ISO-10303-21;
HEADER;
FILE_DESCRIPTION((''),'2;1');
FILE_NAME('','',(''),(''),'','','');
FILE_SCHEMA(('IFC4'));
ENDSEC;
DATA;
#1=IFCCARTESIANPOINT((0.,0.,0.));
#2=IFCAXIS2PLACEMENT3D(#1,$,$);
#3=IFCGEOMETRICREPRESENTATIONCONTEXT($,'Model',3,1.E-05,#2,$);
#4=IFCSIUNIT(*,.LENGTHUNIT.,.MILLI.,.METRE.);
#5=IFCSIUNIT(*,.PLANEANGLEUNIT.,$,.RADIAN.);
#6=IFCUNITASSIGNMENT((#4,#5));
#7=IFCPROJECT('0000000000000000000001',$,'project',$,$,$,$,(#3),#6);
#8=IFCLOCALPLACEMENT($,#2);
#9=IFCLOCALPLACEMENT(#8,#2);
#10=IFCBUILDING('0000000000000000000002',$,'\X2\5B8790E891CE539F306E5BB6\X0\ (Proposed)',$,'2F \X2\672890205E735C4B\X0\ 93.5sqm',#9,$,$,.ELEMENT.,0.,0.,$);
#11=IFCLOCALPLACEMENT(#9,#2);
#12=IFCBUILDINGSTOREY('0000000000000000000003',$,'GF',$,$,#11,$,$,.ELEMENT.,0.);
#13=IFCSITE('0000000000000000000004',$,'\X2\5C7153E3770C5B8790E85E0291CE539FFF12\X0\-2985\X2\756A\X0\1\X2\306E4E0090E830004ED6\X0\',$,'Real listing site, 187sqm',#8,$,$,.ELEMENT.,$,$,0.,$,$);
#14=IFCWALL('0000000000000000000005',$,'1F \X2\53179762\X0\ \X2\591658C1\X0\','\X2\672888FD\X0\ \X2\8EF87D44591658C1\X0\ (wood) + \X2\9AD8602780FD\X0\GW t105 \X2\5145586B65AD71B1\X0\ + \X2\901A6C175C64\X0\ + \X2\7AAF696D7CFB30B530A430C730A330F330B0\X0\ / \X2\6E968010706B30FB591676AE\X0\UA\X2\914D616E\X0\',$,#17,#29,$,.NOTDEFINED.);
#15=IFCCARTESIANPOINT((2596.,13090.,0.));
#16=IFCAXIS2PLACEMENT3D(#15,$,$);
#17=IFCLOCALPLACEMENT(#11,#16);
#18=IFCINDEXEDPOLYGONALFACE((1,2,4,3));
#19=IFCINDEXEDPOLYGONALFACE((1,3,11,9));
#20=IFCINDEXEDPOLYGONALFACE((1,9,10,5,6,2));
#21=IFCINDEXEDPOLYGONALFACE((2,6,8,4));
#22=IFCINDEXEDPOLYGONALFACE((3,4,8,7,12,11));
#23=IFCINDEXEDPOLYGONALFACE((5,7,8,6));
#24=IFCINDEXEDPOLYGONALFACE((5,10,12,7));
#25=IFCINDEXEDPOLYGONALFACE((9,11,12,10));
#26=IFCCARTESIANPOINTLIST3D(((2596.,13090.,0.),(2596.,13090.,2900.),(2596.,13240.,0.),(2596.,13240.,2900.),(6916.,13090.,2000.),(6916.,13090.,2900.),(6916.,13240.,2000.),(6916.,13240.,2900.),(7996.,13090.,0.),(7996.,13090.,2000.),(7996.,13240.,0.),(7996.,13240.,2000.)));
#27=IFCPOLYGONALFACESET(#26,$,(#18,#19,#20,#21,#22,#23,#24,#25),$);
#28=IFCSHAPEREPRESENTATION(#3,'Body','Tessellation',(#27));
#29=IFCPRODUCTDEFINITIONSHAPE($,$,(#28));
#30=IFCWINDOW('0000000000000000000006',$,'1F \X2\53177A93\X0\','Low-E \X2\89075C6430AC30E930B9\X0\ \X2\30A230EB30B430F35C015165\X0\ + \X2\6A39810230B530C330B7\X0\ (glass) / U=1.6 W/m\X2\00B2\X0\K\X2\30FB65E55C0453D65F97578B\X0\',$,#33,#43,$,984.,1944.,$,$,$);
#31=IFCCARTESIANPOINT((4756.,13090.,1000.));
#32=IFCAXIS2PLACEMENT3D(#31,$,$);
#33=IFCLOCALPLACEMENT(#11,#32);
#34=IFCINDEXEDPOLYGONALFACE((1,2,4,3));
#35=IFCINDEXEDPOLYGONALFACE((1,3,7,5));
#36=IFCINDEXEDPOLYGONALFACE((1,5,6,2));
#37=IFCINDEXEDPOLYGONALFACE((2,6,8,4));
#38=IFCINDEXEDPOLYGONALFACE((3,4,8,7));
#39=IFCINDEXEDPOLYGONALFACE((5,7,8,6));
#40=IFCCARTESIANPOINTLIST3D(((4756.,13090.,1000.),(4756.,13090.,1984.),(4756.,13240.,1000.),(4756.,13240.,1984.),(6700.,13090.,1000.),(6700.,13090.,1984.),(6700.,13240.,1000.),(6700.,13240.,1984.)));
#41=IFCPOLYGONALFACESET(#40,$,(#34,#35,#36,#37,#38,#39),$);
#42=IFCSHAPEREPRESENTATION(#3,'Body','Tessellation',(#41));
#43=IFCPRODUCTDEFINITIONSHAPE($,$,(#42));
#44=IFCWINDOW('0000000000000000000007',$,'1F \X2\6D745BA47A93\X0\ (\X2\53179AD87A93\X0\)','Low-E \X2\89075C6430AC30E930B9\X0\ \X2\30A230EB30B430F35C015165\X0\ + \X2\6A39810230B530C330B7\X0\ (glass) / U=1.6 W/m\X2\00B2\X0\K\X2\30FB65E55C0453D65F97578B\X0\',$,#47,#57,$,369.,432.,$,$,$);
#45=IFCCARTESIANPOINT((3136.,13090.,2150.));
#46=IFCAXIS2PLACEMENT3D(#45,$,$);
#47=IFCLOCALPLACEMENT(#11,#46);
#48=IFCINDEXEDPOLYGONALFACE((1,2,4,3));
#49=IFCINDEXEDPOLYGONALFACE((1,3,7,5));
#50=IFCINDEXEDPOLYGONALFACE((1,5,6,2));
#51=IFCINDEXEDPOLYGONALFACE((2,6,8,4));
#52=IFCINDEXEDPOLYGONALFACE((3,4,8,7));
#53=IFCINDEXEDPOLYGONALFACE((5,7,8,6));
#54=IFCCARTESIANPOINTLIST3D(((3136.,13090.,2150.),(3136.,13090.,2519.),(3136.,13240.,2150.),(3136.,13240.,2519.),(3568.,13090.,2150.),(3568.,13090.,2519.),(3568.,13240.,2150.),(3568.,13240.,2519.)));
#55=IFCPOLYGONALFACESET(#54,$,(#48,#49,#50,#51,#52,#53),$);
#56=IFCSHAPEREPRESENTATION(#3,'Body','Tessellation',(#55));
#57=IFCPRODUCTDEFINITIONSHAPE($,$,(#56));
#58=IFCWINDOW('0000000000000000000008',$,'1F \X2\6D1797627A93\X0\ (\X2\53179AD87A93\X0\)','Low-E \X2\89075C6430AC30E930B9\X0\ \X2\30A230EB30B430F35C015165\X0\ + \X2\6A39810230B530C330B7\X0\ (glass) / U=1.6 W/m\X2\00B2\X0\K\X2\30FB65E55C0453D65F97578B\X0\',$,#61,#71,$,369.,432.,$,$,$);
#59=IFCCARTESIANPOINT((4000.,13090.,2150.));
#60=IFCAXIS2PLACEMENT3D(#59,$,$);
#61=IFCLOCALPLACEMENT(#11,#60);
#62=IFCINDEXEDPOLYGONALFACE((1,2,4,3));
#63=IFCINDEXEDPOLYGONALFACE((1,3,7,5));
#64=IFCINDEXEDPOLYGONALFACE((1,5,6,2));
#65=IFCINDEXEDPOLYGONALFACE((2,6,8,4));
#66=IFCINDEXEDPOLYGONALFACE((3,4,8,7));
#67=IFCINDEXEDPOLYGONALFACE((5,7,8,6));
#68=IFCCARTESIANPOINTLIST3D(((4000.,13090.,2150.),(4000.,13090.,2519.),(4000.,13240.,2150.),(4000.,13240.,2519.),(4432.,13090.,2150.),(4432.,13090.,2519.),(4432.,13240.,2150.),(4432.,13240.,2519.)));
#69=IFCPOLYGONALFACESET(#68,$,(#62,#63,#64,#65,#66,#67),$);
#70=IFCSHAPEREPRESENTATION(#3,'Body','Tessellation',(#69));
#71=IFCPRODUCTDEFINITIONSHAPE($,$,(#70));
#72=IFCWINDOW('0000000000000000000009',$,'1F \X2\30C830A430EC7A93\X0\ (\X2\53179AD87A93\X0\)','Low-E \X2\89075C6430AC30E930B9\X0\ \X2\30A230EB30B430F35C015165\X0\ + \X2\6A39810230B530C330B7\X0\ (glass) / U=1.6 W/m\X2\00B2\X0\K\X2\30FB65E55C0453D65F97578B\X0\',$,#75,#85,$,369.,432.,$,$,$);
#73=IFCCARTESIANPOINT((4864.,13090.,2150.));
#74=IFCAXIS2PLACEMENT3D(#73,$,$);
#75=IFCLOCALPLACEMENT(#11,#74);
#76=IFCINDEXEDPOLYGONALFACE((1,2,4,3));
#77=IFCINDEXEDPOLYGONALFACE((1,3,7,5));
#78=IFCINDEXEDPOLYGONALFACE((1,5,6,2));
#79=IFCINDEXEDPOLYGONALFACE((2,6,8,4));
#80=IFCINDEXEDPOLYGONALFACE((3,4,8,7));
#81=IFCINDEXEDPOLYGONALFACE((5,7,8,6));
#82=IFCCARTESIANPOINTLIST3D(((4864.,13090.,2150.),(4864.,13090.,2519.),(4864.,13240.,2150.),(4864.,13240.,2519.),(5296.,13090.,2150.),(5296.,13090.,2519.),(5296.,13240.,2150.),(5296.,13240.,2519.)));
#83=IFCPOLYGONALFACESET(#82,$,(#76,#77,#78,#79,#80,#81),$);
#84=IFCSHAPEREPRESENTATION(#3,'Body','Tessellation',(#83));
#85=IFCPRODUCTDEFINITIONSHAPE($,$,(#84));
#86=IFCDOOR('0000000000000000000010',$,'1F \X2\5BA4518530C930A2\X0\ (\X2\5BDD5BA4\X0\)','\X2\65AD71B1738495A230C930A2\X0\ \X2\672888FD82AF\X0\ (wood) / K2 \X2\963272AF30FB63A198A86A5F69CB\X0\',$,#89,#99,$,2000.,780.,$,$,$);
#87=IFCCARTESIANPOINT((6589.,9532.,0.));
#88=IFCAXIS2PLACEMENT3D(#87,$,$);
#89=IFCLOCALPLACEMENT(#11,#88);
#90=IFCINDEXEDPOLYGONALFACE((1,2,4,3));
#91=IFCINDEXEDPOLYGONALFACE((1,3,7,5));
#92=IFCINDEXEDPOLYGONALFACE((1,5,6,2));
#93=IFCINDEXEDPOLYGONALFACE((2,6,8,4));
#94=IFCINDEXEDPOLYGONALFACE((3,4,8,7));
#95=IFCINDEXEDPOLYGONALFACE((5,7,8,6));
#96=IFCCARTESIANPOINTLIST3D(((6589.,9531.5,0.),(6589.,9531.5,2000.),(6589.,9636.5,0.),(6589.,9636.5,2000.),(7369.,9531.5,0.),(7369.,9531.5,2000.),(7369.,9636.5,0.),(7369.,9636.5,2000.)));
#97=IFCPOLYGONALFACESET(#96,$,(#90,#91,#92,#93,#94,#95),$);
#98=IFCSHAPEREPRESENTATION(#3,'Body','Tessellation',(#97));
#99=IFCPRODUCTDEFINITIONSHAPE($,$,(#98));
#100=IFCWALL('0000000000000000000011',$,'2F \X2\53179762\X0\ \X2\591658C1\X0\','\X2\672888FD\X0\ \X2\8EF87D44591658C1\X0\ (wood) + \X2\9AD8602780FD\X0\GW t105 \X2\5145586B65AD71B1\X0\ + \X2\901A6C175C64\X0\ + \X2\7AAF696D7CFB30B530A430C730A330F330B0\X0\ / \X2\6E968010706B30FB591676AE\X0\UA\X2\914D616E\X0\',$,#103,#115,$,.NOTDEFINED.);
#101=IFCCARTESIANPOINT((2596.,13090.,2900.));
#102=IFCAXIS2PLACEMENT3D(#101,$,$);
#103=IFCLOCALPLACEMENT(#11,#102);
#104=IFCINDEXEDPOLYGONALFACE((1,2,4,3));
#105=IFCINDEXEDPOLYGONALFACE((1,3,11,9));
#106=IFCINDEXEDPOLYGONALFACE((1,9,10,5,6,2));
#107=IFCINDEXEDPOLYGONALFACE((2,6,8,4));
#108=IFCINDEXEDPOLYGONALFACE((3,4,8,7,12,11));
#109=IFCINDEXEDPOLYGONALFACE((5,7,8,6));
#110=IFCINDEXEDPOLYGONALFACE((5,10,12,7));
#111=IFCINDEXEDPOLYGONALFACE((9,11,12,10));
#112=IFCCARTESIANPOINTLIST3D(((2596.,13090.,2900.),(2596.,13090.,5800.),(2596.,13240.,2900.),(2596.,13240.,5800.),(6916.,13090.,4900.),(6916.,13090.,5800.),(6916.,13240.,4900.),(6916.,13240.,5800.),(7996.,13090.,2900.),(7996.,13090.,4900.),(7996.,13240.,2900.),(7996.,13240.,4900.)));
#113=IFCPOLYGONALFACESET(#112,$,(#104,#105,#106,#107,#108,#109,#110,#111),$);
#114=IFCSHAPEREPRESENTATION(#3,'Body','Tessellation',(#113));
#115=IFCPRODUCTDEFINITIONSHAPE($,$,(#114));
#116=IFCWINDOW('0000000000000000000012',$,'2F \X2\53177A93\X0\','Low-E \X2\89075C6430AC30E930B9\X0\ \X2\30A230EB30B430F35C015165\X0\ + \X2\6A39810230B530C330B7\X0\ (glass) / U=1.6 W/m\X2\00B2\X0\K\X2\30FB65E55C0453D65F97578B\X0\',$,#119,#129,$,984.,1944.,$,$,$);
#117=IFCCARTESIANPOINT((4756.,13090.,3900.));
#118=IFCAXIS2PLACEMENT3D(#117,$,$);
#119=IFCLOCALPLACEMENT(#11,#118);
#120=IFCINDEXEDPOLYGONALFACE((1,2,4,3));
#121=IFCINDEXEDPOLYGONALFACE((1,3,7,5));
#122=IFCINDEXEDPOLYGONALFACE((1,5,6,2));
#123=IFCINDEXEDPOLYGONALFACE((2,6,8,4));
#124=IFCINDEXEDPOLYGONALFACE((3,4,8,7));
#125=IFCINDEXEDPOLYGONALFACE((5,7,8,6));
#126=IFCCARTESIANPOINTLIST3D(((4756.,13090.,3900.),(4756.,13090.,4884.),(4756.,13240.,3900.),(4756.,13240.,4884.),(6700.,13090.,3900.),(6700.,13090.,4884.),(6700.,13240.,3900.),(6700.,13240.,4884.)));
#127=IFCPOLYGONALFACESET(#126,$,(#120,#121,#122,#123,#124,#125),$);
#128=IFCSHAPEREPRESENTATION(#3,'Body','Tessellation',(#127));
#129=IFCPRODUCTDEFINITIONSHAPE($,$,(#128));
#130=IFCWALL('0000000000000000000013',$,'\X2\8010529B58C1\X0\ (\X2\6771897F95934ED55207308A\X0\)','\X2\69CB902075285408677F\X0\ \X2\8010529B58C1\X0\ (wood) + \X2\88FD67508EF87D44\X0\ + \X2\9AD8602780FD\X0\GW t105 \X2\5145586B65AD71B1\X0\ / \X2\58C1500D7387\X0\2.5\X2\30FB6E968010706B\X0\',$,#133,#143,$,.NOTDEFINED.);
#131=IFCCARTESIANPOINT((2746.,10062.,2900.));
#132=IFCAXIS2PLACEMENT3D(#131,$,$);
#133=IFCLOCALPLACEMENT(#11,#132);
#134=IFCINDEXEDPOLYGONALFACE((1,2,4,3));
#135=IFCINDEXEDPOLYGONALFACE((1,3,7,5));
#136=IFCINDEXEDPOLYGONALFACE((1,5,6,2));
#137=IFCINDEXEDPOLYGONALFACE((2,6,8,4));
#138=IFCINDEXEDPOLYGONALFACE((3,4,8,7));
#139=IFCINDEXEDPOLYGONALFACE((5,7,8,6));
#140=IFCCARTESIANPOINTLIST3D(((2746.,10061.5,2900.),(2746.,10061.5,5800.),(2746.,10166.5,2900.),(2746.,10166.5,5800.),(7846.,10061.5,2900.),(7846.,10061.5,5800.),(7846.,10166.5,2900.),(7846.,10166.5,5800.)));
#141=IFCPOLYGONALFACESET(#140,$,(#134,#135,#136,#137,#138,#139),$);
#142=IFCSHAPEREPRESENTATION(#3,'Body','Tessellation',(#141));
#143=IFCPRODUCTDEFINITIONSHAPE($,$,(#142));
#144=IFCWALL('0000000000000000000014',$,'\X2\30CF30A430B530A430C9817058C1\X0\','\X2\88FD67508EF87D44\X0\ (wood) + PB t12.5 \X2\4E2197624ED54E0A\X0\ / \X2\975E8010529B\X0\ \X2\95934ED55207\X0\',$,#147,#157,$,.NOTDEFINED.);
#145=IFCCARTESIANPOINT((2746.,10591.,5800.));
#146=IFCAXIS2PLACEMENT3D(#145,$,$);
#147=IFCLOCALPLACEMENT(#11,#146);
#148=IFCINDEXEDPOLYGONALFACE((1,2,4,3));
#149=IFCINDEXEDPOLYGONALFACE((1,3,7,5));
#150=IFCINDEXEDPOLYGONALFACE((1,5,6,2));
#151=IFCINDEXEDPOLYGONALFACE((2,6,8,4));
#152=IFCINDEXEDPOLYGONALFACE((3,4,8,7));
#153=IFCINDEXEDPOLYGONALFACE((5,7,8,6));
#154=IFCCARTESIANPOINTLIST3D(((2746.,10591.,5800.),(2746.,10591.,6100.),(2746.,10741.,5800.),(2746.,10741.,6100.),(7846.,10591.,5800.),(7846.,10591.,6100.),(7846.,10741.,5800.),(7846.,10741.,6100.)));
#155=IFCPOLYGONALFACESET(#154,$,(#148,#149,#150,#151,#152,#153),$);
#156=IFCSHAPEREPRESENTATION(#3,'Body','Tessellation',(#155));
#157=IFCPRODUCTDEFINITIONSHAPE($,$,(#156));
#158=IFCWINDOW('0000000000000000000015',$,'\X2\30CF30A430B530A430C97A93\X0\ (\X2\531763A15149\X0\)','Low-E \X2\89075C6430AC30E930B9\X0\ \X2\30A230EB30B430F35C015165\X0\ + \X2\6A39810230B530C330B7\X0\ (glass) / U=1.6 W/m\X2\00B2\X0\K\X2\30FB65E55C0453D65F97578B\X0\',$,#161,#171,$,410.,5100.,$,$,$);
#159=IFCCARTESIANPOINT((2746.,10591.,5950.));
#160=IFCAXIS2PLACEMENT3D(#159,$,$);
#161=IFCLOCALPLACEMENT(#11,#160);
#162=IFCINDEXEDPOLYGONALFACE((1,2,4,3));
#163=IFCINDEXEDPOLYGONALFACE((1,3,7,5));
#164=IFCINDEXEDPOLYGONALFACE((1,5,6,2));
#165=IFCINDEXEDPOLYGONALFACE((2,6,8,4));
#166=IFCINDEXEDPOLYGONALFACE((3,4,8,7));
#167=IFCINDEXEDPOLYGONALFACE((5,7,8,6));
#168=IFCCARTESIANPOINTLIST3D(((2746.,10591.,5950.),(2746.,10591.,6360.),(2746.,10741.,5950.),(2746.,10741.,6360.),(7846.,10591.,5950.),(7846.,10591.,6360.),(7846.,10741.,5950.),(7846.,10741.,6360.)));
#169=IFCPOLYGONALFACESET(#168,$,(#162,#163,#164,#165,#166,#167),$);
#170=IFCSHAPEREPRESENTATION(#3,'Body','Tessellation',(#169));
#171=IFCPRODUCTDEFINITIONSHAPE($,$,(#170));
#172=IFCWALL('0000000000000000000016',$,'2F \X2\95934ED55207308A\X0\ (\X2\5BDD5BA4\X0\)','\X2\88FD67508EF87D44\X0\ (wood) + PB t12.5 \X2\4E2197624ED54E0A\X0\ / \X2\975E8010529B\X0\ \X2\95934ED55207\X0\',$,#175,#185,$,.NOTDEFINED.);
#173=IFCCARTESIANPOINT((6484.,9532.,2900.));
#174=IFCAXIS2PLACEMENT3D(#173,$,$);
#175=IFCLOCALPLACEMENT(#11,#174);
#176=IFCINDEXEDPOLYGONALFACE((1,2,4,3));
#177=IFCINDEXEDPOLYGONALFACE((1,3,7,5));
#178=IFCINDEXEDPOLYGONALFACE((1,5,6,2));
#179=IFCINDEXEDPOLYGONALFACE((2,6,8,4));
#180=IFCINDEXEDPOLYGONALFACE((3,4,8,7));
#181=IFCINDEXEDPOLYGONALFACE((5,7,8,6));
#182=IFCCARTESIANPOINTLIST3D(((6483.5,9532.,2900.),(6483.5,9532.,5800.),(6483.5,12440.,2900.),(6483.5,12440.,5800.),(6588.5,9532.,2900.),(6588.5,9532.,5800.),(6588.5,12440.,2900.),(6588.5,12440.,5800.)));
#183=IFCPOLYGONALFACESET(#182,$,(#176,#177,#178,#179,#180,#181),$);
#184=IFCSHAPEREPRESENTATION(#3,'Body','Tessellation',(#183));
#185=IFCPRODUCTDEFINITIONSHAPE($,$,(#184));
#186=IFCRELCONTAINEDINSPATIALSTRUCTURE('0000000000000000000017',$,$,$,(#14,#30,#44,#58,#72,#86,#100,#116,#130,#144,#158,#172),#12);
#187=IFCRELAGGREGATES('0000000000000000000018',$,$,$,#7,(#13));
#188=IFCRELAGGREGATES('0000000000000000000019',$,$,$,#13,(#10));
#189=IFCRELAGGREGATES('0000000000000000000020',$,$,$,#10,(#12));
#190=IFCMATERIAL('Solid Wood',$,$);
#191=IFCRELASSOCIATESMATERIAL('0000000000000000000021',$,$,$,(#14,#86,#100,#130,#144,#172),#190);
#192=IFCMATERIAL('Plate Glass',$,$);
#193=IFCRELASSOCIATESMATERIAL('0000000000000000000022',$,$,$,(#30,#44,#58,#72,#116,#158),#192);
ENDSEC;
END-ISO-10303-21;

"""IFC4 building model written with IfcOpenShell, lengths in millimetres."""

from ifc_helpers import new_model, si_unit, frame, frame_2d, origin, place, context, project, spatial, rectangle, extrude, material, element, fill, save


model = new_model("IFC4")

# Units and contexts
model_context = context("Model", 3, precision=1e-05, world=origin())
ifc_project = project(units=[si_unit("LENGTHUNIT", "METRE", prefix="MILLI"), si_unit("PLANEANGLEUNIT", "RADIAN")], contexts=[model_context])

# Site, building, storey
site_placement = place(None, origin())
site = spatial("IfcSite", under=ifc_project, at=site_placement, Name="山口県宇部市野原２-2985番1の一部　他", ObjectType="Real listing site, 187sqm", CompositionType="ELEMENT", RefElevation=0.0)
building_placement = place(site_placement, origin())
building = spatial("IfcBuilding", under=site, at=building_placement, Name="宇部野原の家 (Proposed)", ObjectType="2F 木造平屋 93.5sqm", CompositionType="ELEMENT", ElevationOfRefHeight=0.0, ElevationOfTerrain=0.0)
storey_placement = place(building_placement, origin())
storey = spatial("IfcBuildingStorey", under=building, at=storey_placement, Name="GF", CompositionType="ELEMENT", Elevation=0.0)

# Wall, openings, windows
ifc_material_1 = material(Name="Solid Wood")
wall_1_placement = place(storey_placement, frame((2596.0, 13090.0, 0.0)))
wall_1 = element("IfcWall", 1, at=wall_1_placement, inside=storey, material=ifc_material_1, Name="1F 北面 外壁", Description="木製 軸組外壁 (wood) + 高性能GW t105 充填断熱 + 通気層 + 窯業系サイディング / 準耐火・外皮UA配慮", PredefinedType="NOTDEFINED", context=model_context, shape_type="SweptSolid", body=[
    extrude(rectangle(XDim=5400.0, YDim=150.0, at=frame_2d((2700.0, 75.0))), frame((2596.0, 13090.0, 0.0)), (0.0, 0.0, 1.0), 2900.0),
])
opening_1_placement = place(storey_placement, frame((4756.0, 13090.0, 1000.0)))
opening_1 = element("IfcOpeningElement", 2, at=opening_1_placement, cuts=wall_1, PredefinedType="NOTDEFINED", context=model_context, shape_type="SweptSolid", body=[
    extrude(rectangle(XDim=1944.0, YDim=150.0, at=frame_2d((972.0, 75.0))), frame((4756.0, 13090.0, 1000.0)), (0.0, 0.0, 1.0), 984.0),
])
opening_2_placement = place(storey_placement, frame((3136.0, 13090.0, 2150.0)))
opening_2 = element("IfcOpeningElement", 3, at=opening_2_placement, cuts=wall_1, PredefinedType="NOTDEFINED", context=model_context, shape_type="SweptSolid", body=[
    extrude(rectangle(XDim=432.0, YDim=150.0, at=frame_2d((216.0, 75.0))), frame((3136.0, 13090.0, 2150.0)), (0.0, 0.0, 1.0), 369.0),
])
opening_3_placement = place(storey_placement, frame((4000.0, 13090.0, 2150.0)))
opening_3 = element("IfcOpeningElement", 4, at=opening_3_placement, cuts=wall_1, PredefinedType="NOTDEFINED", context=model_context, shape_type="SweptSolid", body=[
    extrude(rectangle(XDim=432.0, YDim=150.0, at=frame_2d((216.0, 75.0))), frame((4000.0, 13090.0, 2150.0)), (0.0, 0.0, 1.0), 369.0),
])
opening_4_placement = place(storey_placement, frame((4864.0, 13090.0, 2150.0)))
opening_4 = element("IfcOpeningElement", 5, at=opening_4_placement, cuts=wall_1, PredefinedType="NOTDEFINED", context=model_context, shape_type="SweptSolid", body=[
    extrude(rectangle(XDim=432.0, YDim=150.0, at=frame_2d((216.0, 75.0))), frame((4864.0, 13090.0, 2150.0)), (0.0, 0.0, 1.0), 369.0),
])
ifc_material_2 = material(Name="Plate Glass")
window_1_placement = place(storey_placement, frame((4756.0, 13090.0, 1000.0)))
window_1 = element("IfcWindow", 6, at=window_1_placement, inside=storey, material=ifc_material_2, Name="1F 北窓", Description="Low-E 複層ガラス アルゴン封入 + 樹脂サッシ (glass) / U=1.6 W/m²K・日射取得型", OverallHeight=984.0, OverallWidth=1944.0, context=model_context, shape_type="SweptSolid", body=[
    extrude(rectangle(XDim=1944.0, YDim=150.0, at=frame_2d((972.0, 75.0))), frame((4756.0, 13090.0, 1000.0)), (0.0, 0.0, 1.0), 984.0),
])
fill(opening_1, window_1)
window_2_placement = place(storey_placement, frame((3136.0, 13090.0, 2150.0)))
window_2 = element("IfcWindow", 7, at=window_2_placement, inside=storey, material=ifc_material_2, Name="1F 浴室窓 (北高窓)", Description="Low-E 複層ガラス アルゴン封入 + 樹脂サッシ (glass) / U=1.6 W/m²K・日射取得型", OverallHeight=369.0, OverallWidth=432.0, context=model_context, shape_type="SweptSolid", body=[
    extrude(rectangle(XDim=432.0, YDim=150.0, at=frame_2d((216.0, 75.0))), frame((3136.0, 13090.0, 2150.0)), (0.0, 0.0, 1.0), 369.0),
])
fill(opening_2, window_2)
window_3_placement = place(storey_placement, frame((4000.0, 13090.0, 2150.0)))
window_3 = element("IfcWindow", 8, at=window_3_placement, inside=storey, material=ifc_material_2, Name="1F 洗面窓 (北高窓)", Description="Low-E 複層ガラス アルゴン封入 + 樹脂サッシ (glass) / U=1.6 W/m²K・日射取得型", OverallHeight=369.0, OverallWidth=432.0, context=model_context, shape_type="SweptSolid", body=[
    extrude(rectangle(XDim=432.0, YDim=150.0, at=frame_2d((216.0, 75.0))), frame((4000.0, 13090.0, 2150.0)), (0.0, 0.0, 1.0), 369.0),
])
fill(opening_3, window_3)
window_4_placement = place(storey_placement, frame((4864.0, 13090.0, 2150.0)))
window_4 = element("IfcWindow", 9, at=window_4_placement, inside=storey, material=ifc_material_2, Name="1F トイレ窓 (北高窓)", Description="Low-E 複層ガラス アルゴン封入 + 樹脂サッシ (glass) / U=1.6 W/m²K・日射取得型", OverallHeight=369.0, OverallWidth=432.0, context=model_context, shape_type="SweptSolid", body=[
    extrude(rectangle(XDim=432.0, YDim=150.0, at=frame_2d((216.0, 75.0))), frame((4864.0, 13090.0, 2150.0)), (0.0, 0.0, 1.0), 369.0),
])
fill(opening_4, window_4)

# Door
door_1_placement = place(storey_placement, frame((6589.0, 9532.0, 0.0)))
element("IfcDoor", 10, at=door_1_placement, inside=storey, material=ifc_material_1, Name="1F 室内ドア (寝室)", Description="断熱玄関ドア 木製芯 (wood) / K2 防犯・採風機構", OverallHeight=2000.0, OverallWidth=780.0, context=model_context, shape_type="SweptSolid", body=[
    extrude(rectangle(XDim=780.0, YDim=105.0, at=frame_2d((390.0, 52.0))), frame((6589.0, 9532.0, 0.0)), (0.0, 0.0, 1.0), 2000.0),
])

# Wall, opening, window
wall_2_placement = place(storey_placement, frame((2596.0, 13090.0, 2900.0)))
wall_2 = element("IfcWall", 11, at=wall_2_placement, inside=storey, material=ifc_material_1, Name="2F 北面 外壁", Description="木製 軸組外壁 (wood) + 高性能GW t105 充填断熱 + 通気層 + 窯業系サイディング / 準耐火・外皮UA配慮", PredefinedType="NOTDEFINED", context=model_context, shape_type="SweptSolid", body=[
    extrude(rectangle(XDim=5400.0, YDim=150.0, at=frame_2d((2700.0, 75.0))), frame((2596.0, 13090.0, 2900.0)), (0.0, 0.0, 1.0), 2900.0),
])
opening_5_placement = place(storey_placement, frame((4756.0, 13090.0, 3900.0)))
opening_5 = element("IfcOpeningElement", 12, at=opening_5_placement, cuts=wall_2, PredefinedType="NOTDEFINED", context=model_context, shape_type="SweptSolid", body=[
    extrude(rectangle(XDim=1944.0, YDim=150.0, at=frame_2d((972.0, 75.0))), frame((4756.0, 13090.0, 3900.0)), (0.0, 0.0, 1.0), 984.0),
])
window_5_placement = place(storey_placement, frame((4756.0, 13090.0, 3900.0)))
window_5 = element("IfcWindow", 13, at=window_5_placement, inside=storey, material=ifc_material_2, Name="2F 北窓", Description="Low-E 複層ガラス アルゴン封入 + 樹脂サッシ (glass) / U=1.6 W/m²K・日射取得型", OverallHeight=984.0, OverallWidth=1944.0, context=model_context, shape_type="SweptSolid", body=[
    extrude(rectangle(XDim=1944.0, YDim=150.0, at=frame_2d((972.0, 75.0))), frame((4756.0, 13090.0, 3900.0)), (0.0, 0.0, 1.0), 984.0),
])
fill(opening_5, window_5)

# Wall
wall_3_placement = place(storey_placement, frame((2746.0, 10062.0, 2900.0)))
element("IfcWall", 14, at=wall_3_placement, inside=storey, material=ifc_material_1, Name="耐力壁 (東西間仕切り)", Description="構造用合板 耐力壁 (wood) + 製材軸組 + 高性能GW t105 充填断熱 / 壁倍率2.5・準耐火", PredefinedType="NOTDEFINED", context=model_context, shape_type="SweptSolid", body=[
    extrude(rectangle(XDim=5100.0, YDim=105.0, at=frame_2d((2550.0, 52.0))), frame((2746.0, 10062.0, 2900.0)), (0.0, 0.0, 1.0), 2900.0),
])

# Wall, opening, window
wall_4_placement = place(storey_placement, frame((2746.0, 10591.0, 5800.0)))
wall_4 = element("IfcWall", 15, at=wall_4_placement, inside=storey, material=ifc_material_1, Name="ハイサイド腰壁", Description="製材軸組 (wood) + PB t12.5 両面仕上 / 非耐力 間仕切", PredefinedType="NOTDEFINED", context=model_context, shape_type="SweptSolid", body=[
    extrude(rectangle(XDim=5100.0, YDim=150.0, at=frame_2d((2550.0, 75.0))), frame((2746.0, 10591.0, 5800.0)), (0.0, 0.0, 1.0), 700.0),
])
opening_6_placement = place(storey_placement, frame((2746.0, 10591.0, 5950.0)))
opening_6 = element("IfcOpeningElement", 16, at=opening_6_placement, cuts=wall_4, PredefinedType="NOTDEFINED", context=model_context, shape_type="SweptSolid", body=[
    extrude(rectangle(XDim=5100.0, YDim=150.0, at=frame_2d((2550.0, 75.0))), frame((2746.0, 10591.0, 5950.0)), (0.0, 0.0, 1.0), 410.0),
])
window_6_placement = place(storey_placement, frame((2746.0, 10591.0, 5950.0)))
window_6 = element("IfcWindow", 17, at=window_6_placement, inside=storey, material=ifc_material_2, Name="ハイサイド窓 (北採光)", Description="Low-E 複層ガラス アルゴン封入 + 樹脂サッシ (glass) / U=1.6 W/m²K・日射取得型", OverallHeight=410.0, OverallWidth=5100.0, context=model_context, shape_type="SweptSolid", body=[
    extrude(rectangle(XDim=5100.0, YDim=150.0, at=frame_2d((2550.0, 75.0))), frame((2746.0, 10591.0, 5950.0)), (0.0, 0.0, 1.0), 410.0),
])
fill(opening_6, window_6)

# Wall
wall_5_placement = place(storey_placement, frame((6484.0, 9532.0, 2900.0)))
element("IfcWall", 18, at=wall_5_placement, inside=storey, material=ifc_material_1, Name="2F 間仕切り (寝室)", Description="製材軸組 (wood) + PB t12.5 両面仕上 / 非耐力 間仕切", PredefinedType="NOTDEFINED", context=model_context, shape_type="SweptSolid", body=[
    extrude(rectangle(XDim=105.0, YDim=2908.0, at=frame_2d((52.0, 1454.0))), frame((6484.0, 9532.0, 2900.0)), (0.0, 0.0, 1.0), 2900.0),
])

save(model, "model.ifc")
